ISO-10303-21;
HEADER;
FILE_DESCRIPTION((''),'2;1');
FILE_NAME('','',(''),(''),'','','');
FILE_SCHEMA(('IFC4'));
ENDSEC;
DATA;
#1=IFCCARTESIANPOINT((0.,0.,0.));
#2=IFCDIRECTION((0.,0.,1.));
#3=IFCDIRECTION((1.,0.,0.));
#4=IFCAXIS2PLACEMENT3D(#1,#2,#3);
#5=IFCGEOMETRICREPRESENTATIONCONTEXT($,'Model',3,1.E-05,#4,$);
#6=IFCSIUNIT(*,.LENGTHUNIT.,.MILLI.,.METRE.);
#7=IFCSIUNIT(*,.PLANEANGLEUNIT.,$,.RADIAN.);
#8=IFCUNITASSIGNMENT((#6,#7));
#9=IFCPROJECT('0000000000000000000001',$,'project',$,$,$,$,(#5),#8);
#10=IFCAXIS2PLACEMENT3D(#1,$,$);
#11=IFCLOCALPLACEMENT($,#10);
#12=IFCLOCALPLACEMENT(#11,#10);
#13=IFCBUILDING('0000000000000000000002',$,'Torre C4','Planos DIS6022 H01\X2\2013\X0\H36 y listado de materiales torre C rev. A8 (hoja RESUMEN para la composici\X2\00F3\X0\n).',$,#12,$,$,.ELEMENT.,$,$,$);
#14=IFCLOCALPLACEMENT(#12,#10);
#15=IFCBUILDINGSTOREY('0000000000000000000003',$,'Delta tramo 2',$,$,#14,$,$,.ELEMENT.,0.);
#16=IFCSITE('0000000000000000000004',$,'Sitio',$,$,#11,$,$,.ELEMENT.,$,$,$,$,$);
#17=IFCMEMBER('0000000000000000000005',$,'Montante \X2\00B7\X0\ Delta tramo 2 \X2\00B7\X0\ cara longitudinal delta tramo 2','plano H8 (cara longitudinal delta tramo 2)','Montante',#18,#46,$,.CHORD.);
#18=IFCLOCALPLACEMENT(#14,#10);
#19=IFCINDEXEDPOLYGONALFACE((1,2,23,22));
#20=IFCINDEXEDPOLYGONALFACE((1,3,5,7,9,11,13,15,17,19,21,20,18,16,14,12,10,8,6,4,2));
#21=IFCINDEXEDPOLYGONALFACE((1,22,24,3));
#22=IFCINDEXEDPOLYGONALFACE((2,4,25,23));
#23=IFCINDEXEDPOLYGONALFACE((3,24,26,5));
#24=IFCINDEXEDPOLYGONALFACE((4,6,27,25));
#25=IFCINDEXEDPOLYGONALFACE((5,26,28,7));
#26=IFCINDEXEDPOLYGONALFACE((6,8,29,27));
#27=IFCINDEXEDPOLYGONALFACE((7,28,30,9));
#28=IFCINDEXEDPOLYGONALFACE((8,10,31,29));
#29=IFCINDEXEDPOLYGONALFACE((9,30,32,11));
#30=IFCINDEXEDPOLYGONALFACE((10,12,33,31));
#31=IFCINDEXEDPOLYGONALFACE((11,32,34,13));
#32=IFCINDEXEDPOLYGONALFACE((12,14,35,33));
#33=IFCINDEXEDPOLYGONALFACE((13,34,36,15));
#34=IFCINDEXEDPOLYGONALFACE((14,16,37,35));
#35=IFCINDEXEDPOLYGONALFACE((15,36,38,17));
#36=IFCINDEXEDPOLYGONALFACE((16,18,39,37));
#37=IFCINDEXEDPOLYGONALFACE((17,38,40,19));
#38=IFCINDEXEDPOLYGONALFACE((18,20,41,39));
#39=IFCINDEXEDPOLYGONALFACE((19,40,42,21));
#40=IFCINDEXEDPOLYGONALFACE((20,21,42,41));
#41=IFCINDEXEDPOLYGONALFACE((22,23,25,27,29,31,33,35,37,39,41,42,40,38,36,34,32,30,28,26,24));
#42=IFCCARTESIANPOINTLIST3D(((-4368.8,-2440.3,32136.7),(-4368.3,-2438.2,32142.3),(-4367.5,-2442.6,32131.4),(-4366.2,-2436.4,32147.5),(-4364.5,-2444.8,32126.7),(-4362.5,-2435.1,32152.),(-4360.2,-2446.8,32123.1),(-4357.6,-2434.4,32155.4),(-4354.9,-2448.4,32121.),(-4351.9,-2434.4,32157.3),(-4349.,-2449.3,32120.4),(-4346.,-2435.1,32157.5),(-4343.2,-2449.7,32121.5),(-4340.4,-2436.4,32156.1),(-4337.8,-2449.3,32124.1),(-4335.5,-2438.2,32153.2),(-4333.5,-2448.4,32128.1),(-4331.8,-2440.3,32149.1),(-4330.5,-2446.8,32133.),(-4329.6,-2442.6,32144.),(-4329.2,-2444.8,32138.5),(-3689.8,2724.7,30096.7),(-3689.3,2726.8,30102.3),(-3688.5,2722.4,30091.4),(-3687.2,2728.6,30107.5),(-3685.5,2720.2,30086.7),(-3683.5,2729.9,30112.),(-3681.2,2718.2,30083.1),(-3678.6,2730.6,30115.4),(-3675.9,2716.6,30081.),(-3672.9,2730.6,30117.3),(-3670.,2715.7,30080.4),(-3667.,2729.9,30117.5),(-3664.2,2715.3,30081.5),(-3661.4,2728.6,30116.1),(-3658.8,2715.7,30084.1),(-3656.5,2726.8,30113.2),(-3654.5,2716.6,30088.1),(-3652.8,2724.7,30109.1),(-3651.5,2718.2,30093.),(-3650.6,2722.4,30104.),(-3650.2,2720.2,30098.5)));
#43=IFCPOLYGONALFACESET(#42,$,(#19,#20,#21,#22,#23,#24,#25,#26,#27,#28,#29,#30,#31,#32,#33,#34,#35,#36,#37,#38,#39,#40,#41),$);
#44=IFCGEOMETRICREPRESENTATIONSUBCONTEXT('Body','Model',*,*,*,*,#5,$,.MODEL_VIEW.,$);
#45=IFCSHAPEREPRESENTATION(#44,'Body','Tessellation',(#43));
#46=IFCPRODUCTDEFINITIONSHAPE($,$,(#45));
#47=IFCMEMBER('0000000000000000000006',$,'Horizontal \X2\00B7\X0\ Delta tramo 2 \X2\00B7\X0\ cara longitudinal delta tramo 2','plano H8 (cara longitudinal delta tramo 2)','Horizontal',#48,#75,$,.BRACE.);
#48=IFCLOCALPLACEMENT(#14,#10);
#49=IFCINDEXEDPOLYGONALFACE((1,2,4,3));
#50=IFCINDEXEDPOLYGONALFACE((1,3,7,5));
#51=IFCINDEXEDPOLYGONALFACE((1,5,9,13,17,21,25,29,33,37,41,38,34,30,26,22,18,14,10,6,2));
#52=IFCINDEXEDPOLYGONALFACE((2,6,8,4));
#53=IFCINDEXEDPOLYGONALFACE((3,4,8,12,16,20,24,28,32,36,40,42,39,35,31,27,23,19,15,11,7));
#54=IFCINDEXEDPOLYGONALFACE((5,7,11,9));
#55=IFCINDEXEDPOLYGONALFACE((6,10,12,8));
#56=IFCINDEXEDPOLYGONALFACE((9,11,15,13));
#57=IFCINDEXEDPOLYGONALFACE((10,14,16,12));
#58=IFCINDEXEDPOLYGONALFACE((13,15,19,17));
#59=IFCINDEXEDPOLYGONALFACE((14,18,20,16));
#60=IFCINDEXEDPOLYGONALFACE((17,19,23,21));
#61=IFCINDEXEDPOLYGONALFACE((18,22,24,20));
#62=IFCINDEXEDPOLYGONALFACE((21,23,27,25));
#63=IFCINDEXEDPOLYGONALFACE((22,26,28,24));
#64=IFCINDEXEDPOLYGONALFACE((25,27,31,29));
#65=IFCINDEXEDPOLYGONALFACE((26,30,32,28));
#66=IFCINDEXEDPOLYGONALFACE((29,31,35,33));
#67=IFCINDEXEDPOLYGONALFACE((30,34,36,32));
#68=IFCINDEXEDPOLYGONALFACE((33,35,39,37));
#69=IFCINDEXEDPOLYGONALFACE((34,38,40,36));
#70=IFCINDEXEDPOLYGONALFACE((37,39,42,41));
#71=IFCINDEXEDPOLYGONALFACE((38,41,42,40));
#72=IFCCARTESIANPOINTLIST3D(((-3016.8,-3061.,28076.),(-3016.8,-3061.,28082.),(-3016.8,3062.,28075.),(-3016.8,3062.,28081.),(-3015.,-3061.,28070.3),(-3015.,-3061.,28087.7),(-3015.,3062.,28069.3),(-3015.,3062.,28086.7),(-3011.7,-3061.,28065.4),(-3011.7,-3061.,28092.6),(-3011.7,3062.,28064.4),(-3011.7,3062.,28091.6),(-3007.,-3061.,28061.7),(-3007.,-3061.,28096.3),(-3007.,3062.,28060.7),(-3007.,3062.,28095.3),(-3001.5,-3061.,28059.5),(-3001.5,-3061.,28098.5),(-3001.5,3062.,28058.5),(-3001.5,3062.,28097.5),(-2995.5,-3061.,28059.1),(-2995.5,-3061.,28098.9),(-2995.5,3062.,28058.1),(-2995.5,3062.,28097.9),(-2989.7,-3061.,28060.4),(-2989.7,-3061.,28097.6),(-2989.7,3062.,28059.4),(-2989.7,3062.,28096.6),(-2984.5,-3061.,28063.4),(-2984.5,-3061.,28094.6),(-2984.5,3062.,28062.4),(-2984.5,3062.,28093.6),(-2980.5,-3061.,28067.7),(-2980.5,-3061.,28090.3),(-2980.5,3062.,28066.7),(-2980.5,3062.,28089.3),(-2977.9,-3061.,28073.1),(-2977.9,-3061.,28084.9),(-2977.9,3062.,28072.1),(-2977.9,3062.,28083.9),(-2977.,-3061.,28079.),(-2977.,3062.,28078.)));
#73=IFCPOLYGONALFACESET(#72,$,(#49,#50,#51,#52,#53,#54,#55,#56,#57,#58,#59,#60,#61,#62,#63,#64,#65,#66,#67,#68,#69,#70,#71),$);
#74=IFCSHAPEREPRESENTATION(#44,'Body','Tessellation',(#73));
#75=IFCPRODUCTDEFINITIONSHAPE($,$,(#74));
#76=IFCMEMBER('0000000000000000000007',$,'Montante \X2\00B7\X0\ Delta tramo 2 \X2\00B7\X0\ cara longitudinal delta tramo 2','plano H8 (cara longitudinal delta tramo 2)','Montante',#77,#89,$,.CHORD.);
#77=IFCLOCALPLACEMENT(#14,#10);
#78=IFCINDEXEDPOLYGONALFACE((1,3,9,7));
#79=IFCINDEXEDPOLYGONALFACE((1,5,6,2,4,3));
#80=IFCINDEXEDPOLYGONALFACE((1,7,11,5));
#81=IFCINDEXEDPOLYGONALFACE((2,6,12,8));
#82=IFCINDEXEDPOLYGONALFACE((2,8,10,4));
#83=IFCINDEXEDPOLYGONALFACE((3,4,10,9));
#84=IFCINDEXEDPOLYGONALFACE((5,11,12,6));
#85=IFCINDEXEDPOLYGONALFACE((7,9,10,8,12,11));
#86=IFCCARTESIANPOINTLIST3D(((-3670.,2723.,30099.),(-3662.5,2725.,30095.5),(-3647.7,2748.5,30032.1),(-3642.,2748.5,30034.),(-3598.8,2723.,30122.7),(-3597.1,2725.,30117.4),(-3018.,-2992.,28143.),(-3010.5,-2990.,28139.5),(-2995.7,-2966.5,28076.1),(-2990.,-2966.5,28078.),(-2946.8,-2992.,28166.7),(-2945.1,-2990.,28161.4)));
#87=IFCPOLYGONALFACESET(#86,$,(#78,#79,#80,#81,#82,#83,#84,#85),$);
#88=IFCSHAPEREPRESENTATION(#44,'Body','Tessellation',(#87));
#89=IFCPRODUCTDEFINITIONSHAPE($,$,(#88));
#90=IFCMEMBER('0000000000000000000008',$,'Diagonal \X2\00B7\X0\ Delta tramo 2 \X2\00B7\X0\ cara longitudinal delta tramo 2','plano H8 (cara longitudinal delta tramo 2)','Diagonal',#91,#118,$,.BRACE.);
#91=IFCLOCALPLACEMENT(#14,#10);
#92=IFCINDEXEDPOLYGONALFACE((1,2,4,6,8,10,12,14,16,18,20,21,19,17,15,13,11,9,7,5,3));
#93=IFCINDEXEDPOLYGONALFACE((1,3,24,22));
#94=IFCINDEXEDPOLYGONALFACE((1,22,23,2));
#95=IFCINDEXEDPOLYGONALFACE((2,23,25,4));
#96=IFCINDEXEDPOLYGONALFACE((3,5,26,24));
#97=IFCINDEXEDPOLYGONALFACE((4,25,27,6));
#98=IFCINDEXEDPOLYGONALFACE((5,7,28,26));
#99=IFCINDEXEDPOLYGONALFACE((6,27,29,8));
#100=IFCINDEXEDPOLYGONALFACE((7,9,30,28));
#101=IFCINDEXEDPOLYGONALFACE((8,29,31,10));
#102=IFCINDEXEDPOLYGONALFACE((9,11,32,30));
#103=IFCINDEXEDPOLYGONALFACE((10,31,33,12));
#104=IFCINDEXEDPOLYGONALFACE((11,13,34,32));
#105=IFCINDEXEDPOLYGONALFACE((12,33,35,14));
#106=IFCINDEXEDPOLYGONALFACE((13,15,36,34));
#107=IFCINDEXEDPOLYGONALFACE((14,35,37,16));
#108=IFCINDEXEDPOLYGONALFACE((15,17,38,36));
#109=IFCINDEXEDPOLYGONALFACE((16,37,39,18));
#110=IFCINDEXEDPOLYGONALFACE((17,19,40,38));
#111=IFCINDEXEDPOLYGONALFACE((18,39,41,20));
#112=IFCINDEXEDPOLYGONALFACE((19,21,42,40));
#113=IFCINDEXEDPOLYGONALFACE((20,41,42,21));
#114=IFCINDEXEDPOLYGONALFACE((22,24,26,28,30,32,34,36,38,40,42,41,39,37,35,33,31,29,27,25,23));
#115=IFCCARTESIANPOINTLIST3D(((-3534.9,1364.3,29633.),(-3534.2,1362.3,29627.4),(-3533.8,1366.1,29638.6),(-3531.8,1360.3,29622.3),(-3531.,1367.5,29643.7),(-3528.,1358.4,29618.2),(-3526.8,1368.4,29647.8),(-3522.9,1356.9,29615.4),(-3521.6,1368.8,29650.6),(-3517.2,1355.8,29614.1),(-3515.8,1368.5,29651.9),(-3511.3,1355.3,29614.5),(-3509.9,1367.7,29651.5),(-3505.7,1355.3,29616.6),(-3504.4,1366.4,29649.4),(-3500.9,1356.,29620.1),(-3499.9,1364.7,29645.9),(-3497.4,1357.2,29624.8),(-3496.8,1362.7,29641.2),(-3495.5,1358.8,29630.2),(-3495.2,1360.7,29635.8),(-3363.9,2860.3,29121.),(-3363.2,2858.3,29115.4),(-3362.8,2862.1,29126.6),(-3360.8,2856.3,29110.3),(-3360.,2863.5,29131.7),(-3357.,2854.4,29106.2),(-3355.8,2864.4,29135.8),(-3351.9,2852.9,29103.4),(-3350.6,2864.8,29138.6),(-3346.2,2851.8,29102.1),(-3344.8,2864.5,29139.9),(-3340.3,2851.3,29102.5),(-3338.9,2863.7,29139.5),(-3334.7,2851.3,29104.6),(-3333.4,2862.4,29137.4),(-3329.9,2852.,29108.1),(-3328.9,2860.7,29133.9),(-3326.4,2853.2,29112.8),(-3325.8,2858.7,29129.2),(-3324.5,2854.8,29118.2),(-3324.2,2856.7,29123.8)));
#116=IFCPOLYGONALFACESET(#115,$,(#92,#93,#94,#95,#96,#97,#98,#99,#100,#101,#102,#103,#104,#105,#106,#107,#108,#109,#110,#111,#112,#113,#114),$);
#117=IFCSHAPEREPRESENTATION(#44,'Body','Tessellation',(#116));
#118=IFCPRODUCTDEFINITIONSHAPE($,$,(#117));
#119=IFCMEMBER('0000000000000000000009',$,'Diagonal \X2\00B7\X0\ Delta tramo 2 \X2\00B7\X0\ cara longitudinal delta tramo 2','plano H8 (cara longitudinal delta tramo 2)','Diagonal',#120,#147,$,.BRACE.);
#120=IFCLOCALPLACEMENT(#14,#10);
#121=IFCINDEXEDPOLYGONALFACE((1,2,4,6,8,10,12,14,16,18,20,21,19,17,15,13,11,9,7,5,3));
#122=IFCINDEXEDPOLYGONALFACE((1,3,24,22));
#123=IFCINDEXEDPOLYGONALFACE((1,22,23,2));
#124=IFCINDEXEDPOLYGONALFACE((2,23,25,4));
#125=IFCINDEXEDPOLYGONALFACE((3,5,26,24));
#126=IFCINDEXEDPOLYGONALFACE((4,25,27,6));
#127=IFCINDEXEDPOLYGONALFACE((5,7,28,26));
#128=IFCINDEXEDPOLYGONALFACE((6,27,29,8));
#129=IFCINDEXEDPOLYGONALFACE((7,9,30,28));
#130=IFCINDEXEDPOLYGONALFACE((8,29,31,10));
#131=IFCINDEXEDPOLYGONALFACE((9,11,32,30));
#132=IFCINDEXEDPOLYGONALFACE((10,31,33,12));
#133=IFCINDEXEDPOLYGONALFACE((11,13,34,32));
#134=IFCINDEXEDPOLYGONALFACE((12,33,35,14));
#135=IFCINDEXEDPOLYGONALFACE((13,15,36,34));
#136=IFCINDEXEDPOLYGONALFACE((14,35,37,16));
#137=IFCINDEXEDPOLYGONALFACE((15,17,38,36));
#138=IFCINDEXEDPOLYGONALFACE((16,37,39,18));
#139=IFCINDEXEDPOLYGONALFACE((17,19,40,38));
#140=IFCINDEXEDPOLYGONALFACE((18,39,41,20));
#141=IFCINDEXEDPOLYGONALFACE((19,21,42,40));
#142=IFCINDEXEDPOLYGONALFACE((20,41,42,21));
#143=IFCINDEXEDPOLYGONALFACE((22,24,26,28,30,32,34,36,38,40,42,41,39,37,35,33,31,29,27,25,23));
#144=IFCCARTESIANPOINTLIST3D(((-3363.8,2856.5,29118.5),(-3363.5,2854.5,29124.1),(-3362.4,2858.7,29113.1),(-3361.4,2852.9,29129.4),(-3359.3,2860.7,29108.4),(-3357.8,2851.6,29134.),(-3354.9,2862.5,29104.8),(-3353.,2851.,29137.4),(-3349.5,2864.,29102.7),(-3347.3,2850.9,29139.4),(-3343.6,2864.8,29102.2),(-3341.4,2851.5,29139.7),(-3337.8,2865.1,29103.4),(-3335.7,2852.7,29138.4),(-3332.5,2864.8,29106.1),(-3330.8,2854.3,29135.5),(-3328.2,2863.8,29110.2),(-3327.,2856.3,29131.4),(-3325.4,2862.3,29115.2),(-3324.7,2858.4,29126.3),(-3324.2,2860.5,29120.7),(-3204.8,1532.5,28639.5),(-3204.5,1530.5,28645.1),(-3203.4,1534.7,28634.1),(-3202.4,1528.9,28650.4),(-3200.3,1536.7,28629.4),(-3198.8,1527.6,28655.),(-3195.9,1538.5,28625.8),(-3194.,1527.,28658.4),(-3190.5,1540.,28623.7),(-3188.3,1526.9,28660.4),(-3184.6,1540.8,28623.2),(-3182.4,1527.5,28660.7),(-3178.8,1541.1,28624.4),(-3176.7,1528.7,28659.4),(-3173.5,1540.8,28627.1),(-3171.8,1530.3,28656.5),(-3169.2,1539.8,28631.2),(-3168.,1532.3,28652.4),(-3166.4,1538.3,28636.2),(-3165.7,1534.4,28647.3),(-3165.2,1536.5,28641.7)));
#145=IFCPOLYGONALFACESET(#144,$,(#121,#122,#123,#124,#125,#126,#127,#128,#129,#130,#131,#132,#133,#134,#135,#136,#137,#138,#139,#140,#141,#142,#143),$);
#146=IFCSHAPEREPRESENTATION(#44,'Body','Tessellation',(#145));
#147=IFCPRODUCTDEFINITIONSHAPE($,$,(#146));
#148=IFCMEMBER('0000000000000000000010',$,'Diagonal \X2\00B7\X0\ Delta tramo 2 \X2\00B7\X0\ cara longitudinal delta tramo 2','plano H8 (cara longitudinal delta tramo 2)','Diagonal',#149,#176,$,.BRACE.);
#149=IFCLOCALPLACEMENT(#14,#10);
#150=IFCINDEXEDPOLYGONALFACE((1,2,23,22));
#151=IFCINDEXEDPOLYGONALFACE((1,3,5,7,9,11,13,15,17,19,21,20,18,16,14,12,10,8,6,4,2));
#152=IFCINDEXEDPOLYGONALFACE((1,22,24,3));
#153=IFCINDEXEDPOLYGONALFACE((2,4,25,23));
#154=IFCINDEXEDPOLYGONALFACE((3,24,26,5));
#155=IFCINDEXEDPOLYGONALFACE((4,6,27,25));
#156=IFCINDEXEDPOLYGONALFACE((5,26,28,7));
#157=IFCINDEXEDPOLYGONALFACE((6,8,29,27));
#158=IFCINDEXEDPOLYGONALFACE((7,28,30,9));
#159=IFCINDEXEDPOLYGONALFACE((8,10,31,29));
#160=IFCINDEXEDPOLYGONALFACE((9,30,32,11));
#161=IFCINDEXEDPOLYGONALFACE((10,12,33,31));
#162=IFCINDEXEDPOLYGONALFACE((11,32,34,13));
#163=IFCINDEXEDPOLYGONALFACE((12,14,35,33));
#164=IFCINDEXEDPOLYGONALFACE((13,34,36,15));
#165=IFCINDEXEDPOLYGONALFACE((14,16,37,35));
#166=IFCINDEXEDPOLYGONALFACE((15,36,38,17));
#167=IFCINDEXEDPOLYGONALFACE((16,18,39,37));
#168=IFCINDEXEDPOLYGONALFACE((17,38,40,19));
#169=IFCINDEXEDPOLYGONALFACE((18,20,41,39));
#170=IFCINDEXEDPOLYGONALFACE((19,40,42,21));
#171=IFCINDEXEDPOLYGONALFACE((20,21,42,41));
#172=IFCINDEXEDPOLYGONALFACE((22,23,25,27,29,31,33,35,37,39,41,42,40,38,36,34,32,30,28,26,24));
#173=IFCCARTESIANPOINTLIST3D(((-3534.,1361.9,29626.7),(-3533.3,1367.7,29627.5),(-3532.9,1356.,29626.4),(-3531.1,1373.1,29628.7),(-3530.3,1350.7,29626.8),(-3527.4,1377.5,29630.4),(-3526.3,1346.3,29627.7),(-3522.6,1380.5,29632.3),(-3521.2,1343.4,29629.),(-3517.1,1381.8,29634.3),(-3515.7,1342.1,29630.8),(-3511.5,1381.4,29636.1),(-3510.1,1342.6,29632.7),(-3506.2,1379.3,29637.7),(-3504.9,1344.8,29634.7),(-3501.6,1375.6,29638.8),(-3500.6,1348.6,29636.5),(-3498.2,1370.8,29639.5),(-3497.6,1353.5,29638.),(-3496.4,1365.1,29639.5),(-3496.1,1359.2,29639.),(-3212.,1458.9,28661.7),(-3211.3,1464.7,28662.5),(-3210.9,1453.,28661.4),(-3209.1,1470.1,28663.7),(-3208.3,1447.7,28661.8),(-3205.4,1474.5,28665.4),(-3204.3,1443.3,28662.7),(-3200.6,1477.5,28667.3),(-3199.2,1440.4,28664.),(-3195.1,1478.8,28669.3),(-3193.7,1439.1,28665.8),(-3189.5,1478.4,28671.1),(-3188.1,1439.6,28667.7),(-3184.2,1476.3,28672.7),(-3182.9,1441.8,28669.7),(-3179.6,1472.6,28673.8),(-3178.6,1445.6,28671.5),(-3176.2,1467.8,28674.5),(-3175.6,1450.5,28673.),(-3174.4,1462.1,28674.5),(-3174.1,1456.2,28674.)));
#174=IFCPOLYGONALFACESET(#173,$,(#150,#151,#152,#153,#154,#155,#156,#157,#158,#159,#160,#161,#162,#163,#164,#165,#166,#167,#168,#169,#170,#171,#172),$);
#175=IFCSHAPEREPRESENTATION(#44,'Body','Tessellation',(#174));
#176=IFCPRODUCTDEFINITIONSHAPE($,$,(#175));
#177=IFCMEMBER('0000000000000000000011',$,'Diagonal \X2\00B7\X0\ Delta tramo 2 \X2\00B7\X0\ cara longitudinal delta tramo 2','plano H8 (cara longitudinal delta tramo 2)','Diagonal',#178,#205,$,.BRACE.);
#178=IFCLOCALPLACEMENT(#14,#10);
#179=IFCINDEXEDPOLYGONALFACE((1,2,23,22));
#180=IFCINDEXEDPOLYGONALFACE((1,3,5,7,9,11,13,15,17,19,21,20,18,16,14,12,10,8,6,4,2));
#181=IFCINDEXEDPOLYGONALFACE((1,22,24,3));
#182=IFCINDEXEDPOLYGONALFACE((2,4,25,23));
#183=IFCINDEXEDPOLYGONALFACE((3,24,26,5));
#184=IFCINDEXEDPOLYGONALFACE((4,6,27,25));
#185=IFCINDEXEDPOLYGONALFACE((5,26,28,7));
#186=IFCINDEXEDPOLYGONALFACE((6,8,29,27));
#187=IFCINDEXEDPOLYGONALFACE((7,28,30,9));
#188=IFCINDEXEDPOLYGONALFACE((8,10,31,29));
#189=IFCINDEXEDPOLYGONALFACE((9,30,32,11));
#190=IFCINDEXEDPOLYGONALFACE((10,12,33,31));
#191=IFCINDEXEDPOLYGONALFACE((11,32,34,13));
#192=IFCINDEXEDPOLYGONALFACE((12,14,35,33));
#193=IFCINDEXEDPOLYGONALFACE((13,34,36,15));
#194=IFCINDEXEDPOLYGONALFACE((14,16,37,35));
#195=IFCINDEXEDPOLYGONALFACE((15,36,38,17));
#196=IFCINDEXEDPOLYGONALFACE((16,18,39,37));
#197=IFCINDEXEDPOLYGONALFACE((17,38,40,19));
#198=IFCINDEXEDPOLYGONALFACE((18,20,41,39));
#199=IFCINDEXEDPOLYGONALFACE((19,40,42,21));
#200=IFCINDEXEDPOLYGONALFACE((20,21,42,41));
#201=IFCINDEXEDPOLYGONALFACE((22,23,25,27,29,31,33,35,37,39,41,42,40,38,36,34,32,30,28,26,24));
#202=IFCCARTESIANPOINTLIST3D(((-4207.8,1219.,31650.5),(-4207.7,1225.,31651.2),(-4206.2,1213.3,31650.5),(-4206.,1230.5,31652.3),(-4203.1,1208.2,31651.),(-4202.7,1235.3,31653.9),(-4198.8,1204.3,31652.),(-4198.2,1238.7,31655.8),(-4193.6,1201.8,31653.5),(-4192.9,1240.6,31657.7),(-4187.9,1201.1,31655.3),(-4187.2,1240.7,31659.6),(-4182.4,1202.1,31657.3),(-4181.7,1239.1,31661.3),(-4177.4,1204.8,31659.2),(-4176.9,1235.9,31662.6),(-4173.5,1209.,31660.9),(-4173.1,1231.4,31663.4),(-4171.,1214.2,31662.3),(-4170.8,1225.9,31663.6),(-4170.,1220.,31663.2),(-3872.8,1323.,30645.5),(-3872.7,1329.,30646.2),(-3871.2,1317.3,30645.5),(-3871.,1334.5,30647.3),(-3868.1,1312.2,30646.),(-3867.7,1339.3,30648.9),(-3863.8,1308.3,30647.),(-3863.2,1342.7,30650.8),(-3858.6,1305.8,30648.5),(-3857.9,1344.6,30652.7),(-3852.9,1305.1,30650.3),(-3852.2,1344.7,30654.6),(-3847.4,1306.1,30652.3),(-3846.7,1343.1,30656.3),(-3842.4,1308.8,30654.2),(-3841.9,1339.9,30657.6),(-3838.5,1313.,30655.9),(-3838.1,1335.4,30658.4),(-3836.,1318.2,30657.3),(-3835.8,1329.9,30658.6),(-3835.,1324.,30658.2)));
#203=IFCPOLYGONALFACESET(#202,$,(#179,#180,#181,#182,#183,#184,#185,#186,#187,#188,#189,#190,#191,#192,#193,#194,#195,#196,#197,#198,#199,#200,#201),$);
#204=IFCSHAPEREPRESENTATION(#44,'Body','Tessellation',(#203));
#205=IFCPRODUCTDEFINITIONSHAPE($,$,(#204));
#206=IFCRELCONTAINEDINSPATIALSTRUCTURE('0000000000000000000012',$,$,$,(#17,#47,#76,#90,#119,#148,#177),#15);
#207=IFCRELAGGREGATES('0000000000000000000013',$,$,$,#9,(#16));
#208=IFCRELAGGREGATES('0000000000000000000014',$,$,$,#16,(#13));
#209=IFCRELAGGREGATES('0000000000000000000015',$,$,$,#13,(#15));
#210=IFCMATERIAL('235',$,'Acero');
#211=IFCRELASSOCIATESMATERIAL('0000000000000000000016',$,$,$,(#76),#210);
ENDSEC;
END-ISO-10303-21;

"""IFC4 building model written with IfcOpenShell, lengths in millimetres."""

from ifc_helpers import new_model, si_unit, frame, frame_2d, origin, origin_with_axes, place, context, subcontext, project, spatial, circle, l_section, extrude, material, element, save


model = new_model("IFC4")

# Units and contexts
model_context = context("Model", 3, precision=1e-05, world=origin_with_axes())
body_context = subcontext(model_context, "Body", "Model", "MODEL_VIEW")
ifc_project = project(units=[si_unit("LENGTHUNIT", "METRE", prefix="MILLI"), si_unit("PLANEANGLEUNIT", "RADIAN")], contexts=[model_context])

# Site, building, storey
site_placement = place(None, origin())
site = spatial("IfcSite", under=ifc_project, at=site_placement, Name="Sitio", CompositionType="ELEMENT")
building_placement = place(site_placement, origin())
building = spatial("IfcBuilding", under=site, at=building_placement, Name="Torre C4", Description="Planos DIS6022 H01–H36 y listado de materiales torre C rev. A8 (hoja RESUMEN para la composición).", CompositionType="ELEMENT")
storey_placement = place(building_placement, origin())
storey = spatial("IfcBuildingStorey", under=building, at=storey_placement, Name="Delta tramo 2", CompositionType="ELEMENT", Elevation=0.0)

# Members
member_1_placement = place(storey_placement, frame((-3670.0, 2723.0, 30099.0), z_axis=(-0.121366, -0.923207, 0.364635), x_axis=(0.291557, -0.384303, -0.87596)))
element("IfcMember", 1, at=member_1_placement, inside=storey, Name="Montante · Delta tramo 2 · cara longitudinal delta tramo 2", Description="plano H8 (cara longitudinal delta tramo 2)", ObjectType="Montante", PredefinedType="CHORD", context=body_context, shape_type="SweptSolid", body=[
    extrude(circle(Radius=20.0), None, (0.0, 0.0, 1.0), 5594.6),
])
member_2_placement = place(storey_placement, frame((-2997.0, 3062.0, 28078.0), z_axis=(0.0, -1.0, 0.000163), x_axis=(1.0, 0.0, 0.0)))
element("IfcMember", 2, at=member_2_placement, inside=storey, Name="Horizontal · Delta tramo 2 · cara longitudinal delta tramo 2", Description="plano H8 (cara longitudinal delta tramo 2)", ObjectType="Horizontal", PredefinedType="BRACE", context=body_context, shape_type="SweptSolid", body=[
    extrude(circle(Radius=20.0), None, (0.0, 0.0, 1.0), 6123.0),
])
ifc_material = material(Name="235", Category="Acero")
member_3_placement = place(storey_placement, frame((-3670.0, 2723.0, 30099.0), z_axis=(0.107315, -0.940656, -0.321946), x_axis=(0.297462, 0.339361, -0.892385)))
element("IfcMember", 3, at=member_3_placement, inside=storey, material=ifc_material, Name="Montante · Delta tramo 2 · cara longitudinal delta tramo 2", Description="plano H8 (cara longitudinal delta tramo 2)", ObjectType="Montante", PredefinedType="CHORD", context=body_context, shape_type="SweptSolid", body=[
    extrude(l_section(Depth=75.0, Width=75.0, Thickness=6.0, at=frame_2d((37.5, 37.5))), None, (0.0, 0.0, 1.0), 6075.5),
])
member_4_placement = place(storey_placement, frame((-3515.0, 1362.0, 29633.0), z_axis=(0.10752, 0.940639, -0.32193), x_axis=(0.976994, -0.159952, -0.141059)))
element("IfcMember", 4, at=member_4_placement, inside=storey, Name="Diagonal · Delta tramo 2 · cara longitudinal delta tramo 2", Description="plano H8 (cara longitudinal delta tramo 2)", ObjectType="Diagonal", PredefinedType="BRACE", context=body_context, shape_type="SweptSolid", body=[
    extrude(circle(Radius=20.0), None, (0.0, 0.0, 1.0), 1590.4),
])
member_5_placement = place(storey_placement, frame((-3344.0, 2858.0, 29121.0), z_axis=(0.112214, -0.934413, -0.338054), x_axis=(0.964462, 0.020521, 0.263423)))
element("IfcMember", 5, at=member_5_placement, inside=storey, Name="Diagonal · Delta tramo 2 · cara longitudinal delta tramo 2", Description="plano H8 (cara longitudinal delta tramo 2)", ObjectType="Diagonal", PredefinedType="BRACE", context=body_context, shape_type="SweptSolid", body=[
    extrude(circle(Radius=20.0), None, (0.0, 0.0, 1.0), 1416.9),
])
member_6_placement = place(storey_placement, frame((-3515.0, 1362.0, 29633.0), z_axis=(0.315094, 0.094919, -0.944302), x_axis=(0.870343, -0.425656, 0.247629)))
element("IfcMember", 6, at=member_6_placement, inside=storey, Name="Diagonal · Delta tramo 2 · cara longitudinal delta tramo 2", Description="plano H8 (cara longitudinal delta tramo 2)", ObjectType="Diagonal", PredefinedType="BRACE", context=body_context, shape_type="SweptSolid", body=[
    extrude(circle(Radius=20.0), None, (0.0, 0.0, 1.0), 1021.9),
])
member_7_placement = place(storey_placement, frame((-3854.0, 1325.0, 30652.0), z_axis=(-0.314715, -0.097703, 0.944144), x_axis=(0.901862, -0.340939, 0.26534)))
element("IfcMember", 7, at=member_7_placement, inside=storey, Name="Diagonal · Delta tramo 2 · cara longitudinal delta tramo 2", Description="plano H8 (cara longitudinal delta tramo 2)", ObjectType="Diagonal", PredefinedType="BRACE", context=body_context, shape_type="SweptSolid", body=[
    extrude(circle(Radius=20.0), None, (0.0, 0.0, 1.0), 1064.5),
])

save(model, "model.ifc")
